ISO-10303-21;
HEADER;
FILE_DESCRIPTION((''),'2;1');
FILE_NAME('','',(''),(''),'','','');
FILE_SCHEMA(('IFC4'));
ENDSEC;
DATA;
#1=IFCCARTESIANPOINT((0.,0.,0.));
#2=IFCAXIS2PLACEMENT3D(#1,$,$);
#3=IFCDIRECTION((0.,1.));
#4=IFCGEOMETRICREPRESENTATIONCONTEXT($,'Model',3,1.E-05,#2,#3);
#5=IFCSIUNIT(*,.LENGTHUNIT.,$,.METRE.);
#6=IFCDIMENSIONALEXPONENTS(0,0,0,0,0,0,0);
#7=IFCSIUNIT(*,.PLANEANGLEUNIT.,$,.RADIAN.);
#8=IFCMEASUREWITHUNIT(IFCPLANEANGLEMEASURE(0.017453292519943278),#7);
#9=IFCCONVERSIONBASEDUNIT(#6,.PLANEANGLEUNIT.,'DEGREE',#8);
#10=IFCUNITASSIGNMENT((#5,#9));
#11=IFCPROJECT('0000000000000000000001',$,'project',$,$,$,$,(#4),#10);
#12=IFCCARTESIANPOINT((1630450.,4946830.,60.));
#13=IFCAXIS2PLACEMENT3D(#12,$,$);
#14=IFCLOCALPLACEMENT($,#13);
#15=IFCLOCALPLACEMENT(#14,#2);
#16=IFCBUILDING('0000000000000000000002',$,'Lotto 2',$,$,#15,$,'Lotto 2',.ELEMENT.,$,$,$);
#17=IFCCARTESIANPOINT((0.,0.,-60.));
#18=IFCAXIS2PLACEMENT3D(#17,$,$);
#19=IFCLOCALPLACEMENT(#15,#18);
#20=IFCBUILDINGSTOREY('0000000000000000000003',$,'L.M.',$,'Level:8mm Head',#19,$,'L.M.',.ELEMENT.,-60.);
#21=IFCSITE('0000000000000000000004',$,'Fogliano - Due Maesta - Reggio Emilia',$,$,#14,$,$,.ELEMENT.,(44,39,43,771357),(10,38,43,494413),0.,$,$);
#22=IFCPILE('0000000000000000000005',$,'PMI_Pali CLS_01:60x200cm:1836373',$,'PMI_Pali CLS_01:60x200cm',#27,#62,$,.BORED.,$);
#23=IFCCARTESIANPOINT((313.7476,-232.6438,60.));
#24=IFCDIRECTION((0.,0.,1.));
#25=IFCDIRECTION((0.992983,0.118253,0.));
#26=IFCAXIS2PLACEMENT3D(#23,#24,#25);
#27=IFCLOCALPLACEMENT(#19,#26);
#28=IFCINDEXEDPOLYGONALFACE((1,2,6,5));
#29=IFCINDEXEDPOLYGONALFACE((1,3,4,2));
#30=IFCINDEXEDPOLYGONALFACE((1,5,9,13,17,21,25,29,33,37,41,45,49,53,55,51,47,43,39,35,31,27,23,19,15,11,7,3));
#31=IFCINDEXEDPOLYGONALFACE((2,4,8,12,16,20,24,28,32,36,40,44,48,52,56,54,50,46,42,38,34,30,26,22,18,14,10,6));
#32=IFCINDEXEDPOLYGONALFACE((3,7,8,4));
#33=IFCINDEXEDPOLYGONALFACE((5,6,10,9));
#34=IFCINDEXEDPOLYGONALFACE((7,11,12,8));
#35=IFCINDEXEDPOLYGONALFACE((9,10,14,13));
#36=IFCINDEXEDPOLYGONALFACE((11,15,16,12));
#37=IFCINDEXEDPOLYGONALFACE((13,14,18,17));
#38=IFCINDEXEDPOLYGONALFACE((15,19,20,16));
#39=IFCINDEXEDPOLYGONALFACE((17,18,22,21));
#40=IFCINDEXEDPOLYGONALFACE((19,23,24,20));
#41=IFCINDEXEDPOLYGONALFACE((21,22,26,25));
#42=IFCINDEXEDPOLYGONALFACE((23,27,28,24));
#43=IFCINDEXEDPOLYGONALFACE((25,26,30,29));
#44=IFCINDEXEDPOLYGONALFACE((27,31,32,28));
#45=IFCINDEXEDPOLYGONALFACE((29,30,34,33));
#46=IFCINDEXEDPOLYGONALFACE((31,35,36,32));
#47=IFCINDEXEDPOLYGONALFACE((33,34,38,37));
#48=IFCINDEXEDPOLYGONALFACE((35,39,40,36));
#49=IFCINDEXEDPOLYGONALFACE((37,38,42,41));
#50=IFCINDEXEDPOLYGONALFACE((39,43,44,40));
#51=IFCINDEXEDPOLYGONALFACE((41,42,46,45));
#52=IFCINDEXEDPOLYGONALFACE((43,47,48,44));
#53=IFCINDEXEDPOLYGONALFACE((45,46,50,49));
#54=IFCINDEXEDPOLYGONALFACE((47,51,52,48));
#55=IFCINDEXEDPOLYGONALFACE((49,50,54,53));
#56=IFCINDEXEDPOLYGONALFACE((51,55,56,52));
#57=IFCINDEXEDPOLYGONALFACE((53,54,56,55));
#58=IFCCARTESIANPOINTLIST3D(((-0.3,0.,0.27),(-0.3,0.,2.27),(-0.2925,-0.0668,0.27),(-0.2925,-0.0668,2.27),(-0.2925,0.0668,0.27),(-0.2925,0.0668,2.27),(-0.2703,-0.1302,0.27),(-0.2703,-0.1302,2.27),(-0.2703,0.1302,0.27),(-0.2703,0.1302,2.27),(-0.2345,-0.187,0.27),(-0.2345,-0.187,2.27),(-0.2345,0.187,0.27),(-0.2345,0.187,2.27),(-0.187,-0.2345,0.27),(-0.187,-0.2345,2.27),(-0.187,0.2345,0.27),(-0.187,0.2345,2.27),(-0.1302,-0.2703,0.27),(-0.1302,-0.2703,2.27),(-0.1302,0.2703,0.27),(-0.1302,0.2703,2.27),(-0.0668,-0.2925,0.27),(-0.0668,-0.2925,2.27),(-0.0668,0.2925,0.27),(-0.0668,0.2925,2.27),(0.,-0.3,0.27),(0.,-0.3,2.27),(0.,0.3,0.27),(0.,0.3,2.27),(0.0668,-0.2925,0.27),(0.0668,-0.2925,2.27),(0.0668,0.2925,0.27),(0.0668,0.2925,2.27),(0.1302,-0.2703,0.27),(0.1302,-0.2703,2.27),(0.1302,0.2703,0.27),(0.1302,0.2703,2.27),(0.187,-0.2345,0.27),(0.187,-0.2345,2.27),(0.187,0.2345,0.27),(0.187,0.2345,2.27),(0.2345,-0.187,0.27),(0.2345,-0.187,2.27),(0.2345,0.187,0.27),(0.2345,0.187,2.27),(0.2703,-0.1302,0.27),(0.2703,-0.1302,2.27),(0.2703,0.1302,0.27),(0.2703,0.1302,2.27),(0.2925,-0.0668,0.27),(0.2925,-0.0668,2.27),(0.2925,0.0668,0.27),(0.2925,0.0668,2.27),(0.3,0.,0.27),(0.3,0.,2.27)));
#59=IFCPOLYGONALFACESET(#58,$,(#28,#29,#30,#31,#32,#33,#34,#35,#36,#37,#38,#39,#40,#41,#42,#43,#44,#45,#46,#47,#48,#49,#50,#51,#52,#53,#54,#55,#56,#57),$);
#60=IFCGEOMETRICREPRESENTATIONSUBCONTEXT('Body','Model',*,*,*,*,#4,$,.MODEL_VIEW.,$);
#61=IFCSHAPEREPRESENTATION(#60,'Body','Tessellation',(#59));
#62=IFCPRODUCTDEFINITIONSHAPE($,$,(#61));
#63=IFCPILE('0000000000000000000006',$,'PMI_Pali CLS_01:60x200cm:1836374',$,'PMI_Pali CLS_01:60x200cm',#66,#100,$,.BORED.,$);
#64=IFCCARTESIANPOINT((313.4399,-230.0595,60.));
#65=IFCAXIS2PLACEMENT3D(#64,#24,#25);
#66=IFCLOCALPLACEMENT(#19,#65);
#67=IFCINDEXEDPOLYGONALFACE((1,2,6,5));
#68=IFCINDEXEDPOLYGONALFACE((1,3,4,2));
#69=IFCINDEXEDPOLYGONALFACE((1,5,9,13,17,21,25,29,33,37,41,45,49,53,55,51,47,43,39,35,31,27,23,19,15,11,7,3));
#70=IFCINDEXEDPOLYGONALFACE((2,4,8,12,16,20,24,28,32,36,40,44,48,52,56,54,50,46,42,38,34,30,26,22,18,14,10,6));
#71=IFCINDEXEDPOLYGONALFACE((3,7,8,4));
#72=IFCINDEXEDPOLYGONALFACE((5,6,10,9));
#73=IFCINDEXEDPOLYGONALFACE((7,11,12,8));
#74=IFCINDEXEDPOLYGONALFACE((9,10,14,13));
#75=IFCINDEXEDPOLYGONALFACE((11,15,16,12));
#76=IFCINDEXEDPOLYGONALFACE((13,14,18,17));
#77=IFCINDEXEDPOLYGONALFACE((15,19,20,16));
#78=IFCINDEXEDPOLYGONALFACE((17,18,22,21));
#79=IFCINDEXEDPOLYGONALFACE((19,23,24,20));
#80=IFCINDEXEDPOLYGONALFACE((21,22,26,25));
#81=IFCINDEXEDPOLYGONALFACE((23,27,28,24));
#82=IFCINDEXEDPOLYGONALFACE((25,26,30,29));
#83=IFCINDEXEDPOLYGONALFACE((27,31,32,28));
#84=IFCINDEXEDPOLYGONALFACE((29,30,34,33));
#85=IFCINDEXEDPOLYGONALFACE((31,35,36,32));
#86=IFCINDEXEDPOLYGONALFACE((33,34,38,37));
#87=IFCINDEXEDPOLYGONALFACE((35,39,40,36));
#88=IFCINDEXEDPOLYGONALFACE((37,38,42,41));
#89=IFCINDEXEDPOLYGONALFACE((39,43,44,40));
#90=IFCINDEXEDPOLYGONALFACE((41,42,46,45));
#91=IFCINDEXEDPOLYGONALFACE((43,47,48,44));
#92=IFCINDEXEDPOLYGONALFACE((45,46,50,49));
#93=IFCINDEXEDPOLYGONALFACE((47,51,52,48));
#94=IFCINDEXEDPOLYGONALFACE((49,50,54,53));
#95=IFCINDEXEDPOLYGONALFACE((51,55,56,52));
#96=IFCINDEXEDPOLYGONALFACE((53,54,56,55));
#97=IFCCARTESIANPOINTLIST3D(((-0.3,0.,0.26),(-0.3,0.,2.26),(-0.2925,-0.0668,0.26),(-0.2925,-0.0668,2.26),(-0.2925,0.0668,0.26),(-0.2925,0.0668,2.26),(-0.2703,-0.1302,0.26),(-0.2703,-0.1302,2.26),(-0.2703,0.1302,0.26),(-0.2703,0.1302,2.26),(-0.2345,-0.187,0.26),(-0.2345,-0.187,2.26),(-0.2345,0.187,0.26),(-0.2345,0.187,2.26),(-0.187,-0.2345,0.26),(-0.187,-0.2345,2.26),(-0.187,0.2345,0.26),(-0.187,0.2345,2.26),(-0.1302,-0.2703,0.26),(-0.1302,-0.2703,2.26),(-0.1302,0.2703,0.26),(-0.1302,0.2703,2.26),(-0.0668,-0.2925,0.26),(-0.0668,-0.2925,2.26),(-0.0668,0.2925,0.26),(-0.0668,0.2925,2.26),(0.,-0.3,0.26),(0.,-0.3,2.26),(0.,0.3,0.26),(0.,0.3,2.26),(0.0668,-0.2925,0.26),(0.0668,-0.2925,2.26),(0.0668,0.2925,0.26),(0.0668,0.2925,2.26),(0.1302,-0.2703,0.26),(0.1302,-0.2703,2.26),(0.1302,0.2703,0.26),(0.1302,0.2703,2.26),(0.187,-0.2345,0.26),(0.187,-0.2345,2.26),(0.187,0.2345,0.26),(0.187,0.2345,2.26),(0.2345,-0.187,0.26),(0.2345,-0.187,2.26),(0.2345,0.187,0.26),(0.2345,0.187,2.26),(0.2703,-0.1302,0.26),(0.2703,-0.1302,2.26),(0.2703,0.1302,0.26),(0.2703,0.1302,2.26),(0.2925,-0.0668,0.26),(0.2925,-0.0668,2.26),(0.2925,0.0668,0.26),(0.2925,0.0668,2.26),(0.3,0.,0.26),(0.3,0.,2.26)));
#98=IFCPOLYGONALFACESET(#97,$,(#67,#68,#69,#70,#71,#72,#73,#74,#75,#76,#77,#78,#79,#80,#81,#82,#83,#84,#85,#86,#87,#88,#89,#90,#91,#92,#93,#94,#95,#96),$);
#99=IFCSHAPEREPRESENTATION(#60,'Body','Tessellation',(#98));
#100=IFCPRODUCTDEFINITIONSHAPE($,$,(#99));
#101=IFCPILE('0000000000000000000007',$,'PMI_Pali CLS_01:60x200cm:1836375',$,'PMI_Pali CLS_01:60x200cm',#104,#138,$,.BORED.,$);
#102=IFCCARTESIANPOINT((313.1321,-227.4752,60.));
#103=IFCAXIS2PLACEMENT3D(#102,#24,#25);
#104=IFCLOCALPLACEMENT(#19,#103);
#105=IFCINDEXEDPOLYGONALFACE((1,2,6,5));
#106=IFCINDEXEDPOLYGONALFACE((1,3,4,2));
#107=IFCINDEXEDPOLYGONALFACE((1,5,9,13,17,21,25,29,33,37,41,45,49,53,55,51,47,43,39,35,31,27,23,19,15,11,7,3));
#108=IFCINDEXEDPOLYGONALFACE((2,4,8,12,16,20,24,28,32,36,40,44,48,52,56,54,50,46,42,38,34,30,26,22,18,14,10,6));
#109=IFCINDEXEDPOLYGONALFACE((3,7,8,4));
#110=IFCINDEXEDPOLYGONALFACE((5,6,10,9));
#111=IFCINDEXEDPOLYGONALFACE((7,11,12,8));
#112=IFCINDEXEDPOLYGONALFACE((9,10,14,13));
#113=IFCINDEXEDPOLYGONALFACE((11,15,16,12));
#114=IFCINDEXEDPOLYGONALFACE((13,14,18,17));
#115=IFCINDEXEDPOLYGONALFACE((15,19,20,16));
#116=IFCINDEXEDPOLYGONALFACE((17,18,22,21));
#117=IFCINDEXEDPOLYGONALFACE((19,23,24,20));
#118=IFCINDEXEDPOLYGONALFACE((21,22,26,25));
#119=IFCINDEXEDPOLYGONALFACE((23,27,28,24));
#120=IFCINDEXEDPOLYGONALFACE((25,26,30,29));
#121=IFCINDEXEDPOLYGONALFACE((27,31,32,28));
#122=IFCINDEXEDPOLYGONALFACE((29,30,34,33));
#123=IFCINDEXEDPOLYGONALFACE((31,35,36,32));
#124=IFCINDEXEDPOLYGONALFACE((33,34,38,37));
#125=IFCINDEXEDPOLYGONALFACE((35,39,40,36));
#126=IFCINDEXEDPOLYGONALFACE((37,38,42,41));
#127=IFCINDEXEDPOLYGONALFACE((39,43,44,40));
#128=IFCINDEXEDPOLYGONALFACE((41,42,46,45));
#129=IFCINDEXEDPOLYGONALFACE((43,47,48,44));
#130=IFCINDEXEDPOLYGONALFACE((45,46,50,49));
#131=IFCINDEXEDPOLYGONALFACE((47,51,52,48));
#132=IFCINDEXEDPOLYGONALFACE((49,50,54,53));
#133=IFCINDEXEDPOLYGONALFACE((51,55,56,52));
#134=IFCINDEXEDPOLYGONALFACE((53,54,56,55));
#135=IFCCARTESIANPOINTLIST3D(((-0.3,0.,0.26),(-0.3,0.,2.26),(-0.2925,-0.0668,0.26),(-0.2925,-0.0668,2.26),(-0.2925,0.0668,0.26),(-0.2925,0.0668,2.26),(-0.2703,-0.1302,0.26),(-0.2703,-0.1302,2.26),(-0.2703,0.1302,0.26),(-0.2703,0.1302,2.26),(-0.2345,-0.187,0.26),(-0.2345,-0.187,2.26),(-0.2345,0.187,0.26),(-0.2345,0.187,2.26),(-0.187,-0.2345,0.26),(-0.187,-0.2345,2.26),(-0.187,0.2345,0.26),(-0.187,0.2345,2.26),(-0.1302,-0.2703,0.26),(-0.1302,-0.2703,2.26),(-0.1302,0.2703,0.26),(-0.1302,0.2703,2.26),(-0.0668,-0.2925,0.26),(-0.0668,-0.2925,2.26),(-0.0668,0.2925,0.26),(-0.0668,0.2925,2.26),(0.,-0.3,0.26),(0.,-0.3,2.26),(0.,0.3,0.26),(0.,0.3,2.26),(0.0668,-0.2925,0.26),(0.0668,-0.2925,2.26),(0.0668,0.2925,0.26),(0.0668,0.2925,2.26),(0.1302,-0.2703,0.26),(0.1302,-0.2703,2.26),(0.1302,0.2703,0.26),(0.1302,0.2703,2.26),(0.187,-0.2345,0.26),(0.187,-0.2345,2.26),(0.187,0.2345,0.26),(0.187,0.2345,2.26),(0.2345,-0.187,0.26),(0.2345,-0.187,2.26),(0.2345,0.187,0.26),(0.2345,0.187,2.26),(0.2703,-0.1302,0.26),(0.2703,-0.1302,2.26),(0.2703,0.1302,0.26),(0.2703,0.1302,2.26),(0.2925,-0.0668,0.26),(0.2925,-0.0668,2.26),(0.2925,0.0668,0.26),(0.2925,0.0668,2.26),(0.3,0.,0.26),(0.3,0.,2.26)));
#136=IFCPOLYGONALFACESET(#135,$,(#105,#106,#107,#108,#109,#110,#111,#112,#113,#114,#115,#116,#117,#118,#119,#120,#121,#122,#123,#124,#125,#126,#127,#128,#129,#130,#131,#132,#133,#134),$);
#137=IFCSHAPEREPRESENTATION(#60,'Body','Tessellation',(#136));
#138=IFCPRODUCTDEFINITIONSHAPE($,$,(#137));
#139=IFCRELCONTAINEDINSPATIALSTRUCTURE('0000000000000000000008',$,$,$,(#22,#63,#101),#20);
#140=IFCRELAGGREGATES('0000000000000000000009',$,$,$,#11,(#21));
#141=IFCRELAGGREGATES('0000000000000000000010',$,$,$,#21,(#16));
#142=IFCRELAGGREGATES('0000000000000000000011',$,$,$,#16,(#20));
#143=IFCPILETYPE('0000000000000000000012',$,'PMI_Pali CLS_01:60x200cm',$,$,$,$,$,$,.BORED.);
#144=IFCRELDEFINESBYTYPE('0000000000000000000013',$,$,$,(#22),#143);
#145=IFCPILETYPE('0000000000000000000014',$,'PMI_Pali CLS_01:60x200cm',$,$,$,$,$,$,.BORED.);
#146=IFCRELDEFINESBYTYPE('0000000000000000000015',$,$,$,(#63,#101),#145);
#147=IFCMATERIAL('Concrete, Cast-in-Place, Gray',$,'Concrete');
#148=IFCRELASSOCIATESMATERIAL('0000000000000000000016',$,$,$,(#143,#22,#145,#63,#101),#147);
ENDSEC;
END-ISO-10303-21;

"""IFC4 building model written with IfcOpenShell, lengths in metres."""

from ifc_helpers import new_model, entity, si_unit, converted_unit, direction, frame, origin, place, context, subcontext, project, spatial, arc, indexed_curve, outline, extrude, source, transform, mapped, material, type_object, type_shapes, element, save


model = new_model("IFC4")

# Units and contexts
model_context = context("Model", 3, precision=1e-05, world=origin(), true_north=direction((0.0, 1.0)))
body_context = subcontext(model_context, "Body", "Model", "MODEL_VIEW")
ifc_project = project(units=[si_unit("LENGTHUNIT", "METRE"), converted_unit("PLANEANGLEUNIT", "DEGREE", entity("IfcPlaneAngleMeasure", 0.017453292519943278), si_unit("PLANEANGLEUNIT", "RADIAN"), dimensions=[0, 0, 0, 0, 0, 0, 0])], contexts=[model_context])

# Site, building, storey
site_placement = place(None, frame((1630450.0, 4946830.0, 60.0)))
site = spatial("IfcSite", under=ifc_project, at=site_placement, Name="Fogliano - Due Maesta - Reggio Emilia", CompositionType="ELEMENT", RefLatitude=(44, 39, 43, 771357), RefLongitude=(10, 38, 43, 494413), RefElevation=0.0)
building_placement = place(site_placement, origin())
building = spatial("IfcBuilding", under=site, at=building_placement, Name="Lotto 2", LongName="Lotto 2", CompositionType="ELEMENT")
storey_placement = place(building_placement, frame((0.0, 0.0, -60.0)))
storey = spatial("IfcBuildingStorey", under=building, at=storey_placement, Name="L.M.", ObjectType="Level:8mm Head", LongName="L.M.", CompositionType="ELEMENT", Elevation=-60.0)

# Piles
ifc_material_1 = material(Name="Concrete, Cast-in-Place, Gray", Category="Concrete")
pile_type_1 = type_object("IfcPileType", Name="PMI_Pali CLS_01:60x200cm", PredefinedType="BORED", material=ifc_material_1)
shared_shape_1 = source(origin(), body_context, "Body", "SweptSolid", [
    extrude(outline(indexed_curve([(-0.3, 0.0), (0.0, -0.3), (0.3, 0.0), (0.0, 0.3)], segments=[arc(1, 2, 3), arc(3, 4, 1)], self_intersect=False)), frame((0.0, 0.0, 0.27)), (0.0, 0.0, 1.0), 2.0),
])
type_shapes(pile_type_1, [shared_shape_1])
pile_1_placement = place(storey_placement, frame((313.7476, -232.6438, 60.0), z_axis=(0.0, 0.0, 1.0), x_axis=(0.992983, 0.118253, 0.0)))
element("IfcPile", 1, at=pile_1_placement, inside=storey, type_object=pile_type_1, material=ifc_material_1, Name="PMI_Pali CLS_01:60x200cm:1836373", ObjectType="PMI_Pali CLS_01:60x200cm", PredefinedType="BORED", context=body_context, shape_type="MappedRepresentation", body=[
    mapped(shared_shape_1, transform((0.0, 0.0, 0.0), scale=1.0)),
])
pile_type_2 = type_object("IfcPileType", Name="PMI_Pali CLS_01:60x200cm", PredefinedType="BORED", material=ifc_material_1)
shared_shape_2 = source(origin(), body_context, "Body", "SweptSolid", [
    extrude(outline(indexed_curve([(-0.3, 0.0), (0.0, -0.3), (0.3, 0.0), (0.0, 0.3)], segments=[arc(1, 2, 3), arc(3, 4, 1)], self_intersect=False)), frame((0.0, 0.0, 0.26)), (0.0, 0.0, 1.0), 2.0),
])
type_shapes(pile_type_2, [shared_shape_2])
for number, where, z_axis, x_axis, name in (
    (2, (313.4399, -230.0595, 60.0), (0.0, 0.0, 1.0), (0.992983, 0.118253, 0.0), "PMI_Pali CLS_01:60x200cm:1836374"),
    (3, (313.1321, -227.4752, 60.0), (0.0, 0.0, 1.0), (0.992983, 0.118253, 0.0), "PMI_Pali CLS_01:60x200cm:1836375"),
):
    element("IfcPile", number, at=place(storey_placement, frame(where, z_axis=z_axis, x_axis=x_axis)), inside=storey, type_object=pile_type_2, material=ifc_material_1, Name=name, ObjectType="PMI_Pali CLS_01:60x200cm", PredefinedType="BORED", context=body_context, shape_type="MappedRepresentation", body=[
        mapped(shared_shape_2, transform((0.0, 0.0, 0.0), scale=1.0)),
    ])

save(model, "model.ifc")
